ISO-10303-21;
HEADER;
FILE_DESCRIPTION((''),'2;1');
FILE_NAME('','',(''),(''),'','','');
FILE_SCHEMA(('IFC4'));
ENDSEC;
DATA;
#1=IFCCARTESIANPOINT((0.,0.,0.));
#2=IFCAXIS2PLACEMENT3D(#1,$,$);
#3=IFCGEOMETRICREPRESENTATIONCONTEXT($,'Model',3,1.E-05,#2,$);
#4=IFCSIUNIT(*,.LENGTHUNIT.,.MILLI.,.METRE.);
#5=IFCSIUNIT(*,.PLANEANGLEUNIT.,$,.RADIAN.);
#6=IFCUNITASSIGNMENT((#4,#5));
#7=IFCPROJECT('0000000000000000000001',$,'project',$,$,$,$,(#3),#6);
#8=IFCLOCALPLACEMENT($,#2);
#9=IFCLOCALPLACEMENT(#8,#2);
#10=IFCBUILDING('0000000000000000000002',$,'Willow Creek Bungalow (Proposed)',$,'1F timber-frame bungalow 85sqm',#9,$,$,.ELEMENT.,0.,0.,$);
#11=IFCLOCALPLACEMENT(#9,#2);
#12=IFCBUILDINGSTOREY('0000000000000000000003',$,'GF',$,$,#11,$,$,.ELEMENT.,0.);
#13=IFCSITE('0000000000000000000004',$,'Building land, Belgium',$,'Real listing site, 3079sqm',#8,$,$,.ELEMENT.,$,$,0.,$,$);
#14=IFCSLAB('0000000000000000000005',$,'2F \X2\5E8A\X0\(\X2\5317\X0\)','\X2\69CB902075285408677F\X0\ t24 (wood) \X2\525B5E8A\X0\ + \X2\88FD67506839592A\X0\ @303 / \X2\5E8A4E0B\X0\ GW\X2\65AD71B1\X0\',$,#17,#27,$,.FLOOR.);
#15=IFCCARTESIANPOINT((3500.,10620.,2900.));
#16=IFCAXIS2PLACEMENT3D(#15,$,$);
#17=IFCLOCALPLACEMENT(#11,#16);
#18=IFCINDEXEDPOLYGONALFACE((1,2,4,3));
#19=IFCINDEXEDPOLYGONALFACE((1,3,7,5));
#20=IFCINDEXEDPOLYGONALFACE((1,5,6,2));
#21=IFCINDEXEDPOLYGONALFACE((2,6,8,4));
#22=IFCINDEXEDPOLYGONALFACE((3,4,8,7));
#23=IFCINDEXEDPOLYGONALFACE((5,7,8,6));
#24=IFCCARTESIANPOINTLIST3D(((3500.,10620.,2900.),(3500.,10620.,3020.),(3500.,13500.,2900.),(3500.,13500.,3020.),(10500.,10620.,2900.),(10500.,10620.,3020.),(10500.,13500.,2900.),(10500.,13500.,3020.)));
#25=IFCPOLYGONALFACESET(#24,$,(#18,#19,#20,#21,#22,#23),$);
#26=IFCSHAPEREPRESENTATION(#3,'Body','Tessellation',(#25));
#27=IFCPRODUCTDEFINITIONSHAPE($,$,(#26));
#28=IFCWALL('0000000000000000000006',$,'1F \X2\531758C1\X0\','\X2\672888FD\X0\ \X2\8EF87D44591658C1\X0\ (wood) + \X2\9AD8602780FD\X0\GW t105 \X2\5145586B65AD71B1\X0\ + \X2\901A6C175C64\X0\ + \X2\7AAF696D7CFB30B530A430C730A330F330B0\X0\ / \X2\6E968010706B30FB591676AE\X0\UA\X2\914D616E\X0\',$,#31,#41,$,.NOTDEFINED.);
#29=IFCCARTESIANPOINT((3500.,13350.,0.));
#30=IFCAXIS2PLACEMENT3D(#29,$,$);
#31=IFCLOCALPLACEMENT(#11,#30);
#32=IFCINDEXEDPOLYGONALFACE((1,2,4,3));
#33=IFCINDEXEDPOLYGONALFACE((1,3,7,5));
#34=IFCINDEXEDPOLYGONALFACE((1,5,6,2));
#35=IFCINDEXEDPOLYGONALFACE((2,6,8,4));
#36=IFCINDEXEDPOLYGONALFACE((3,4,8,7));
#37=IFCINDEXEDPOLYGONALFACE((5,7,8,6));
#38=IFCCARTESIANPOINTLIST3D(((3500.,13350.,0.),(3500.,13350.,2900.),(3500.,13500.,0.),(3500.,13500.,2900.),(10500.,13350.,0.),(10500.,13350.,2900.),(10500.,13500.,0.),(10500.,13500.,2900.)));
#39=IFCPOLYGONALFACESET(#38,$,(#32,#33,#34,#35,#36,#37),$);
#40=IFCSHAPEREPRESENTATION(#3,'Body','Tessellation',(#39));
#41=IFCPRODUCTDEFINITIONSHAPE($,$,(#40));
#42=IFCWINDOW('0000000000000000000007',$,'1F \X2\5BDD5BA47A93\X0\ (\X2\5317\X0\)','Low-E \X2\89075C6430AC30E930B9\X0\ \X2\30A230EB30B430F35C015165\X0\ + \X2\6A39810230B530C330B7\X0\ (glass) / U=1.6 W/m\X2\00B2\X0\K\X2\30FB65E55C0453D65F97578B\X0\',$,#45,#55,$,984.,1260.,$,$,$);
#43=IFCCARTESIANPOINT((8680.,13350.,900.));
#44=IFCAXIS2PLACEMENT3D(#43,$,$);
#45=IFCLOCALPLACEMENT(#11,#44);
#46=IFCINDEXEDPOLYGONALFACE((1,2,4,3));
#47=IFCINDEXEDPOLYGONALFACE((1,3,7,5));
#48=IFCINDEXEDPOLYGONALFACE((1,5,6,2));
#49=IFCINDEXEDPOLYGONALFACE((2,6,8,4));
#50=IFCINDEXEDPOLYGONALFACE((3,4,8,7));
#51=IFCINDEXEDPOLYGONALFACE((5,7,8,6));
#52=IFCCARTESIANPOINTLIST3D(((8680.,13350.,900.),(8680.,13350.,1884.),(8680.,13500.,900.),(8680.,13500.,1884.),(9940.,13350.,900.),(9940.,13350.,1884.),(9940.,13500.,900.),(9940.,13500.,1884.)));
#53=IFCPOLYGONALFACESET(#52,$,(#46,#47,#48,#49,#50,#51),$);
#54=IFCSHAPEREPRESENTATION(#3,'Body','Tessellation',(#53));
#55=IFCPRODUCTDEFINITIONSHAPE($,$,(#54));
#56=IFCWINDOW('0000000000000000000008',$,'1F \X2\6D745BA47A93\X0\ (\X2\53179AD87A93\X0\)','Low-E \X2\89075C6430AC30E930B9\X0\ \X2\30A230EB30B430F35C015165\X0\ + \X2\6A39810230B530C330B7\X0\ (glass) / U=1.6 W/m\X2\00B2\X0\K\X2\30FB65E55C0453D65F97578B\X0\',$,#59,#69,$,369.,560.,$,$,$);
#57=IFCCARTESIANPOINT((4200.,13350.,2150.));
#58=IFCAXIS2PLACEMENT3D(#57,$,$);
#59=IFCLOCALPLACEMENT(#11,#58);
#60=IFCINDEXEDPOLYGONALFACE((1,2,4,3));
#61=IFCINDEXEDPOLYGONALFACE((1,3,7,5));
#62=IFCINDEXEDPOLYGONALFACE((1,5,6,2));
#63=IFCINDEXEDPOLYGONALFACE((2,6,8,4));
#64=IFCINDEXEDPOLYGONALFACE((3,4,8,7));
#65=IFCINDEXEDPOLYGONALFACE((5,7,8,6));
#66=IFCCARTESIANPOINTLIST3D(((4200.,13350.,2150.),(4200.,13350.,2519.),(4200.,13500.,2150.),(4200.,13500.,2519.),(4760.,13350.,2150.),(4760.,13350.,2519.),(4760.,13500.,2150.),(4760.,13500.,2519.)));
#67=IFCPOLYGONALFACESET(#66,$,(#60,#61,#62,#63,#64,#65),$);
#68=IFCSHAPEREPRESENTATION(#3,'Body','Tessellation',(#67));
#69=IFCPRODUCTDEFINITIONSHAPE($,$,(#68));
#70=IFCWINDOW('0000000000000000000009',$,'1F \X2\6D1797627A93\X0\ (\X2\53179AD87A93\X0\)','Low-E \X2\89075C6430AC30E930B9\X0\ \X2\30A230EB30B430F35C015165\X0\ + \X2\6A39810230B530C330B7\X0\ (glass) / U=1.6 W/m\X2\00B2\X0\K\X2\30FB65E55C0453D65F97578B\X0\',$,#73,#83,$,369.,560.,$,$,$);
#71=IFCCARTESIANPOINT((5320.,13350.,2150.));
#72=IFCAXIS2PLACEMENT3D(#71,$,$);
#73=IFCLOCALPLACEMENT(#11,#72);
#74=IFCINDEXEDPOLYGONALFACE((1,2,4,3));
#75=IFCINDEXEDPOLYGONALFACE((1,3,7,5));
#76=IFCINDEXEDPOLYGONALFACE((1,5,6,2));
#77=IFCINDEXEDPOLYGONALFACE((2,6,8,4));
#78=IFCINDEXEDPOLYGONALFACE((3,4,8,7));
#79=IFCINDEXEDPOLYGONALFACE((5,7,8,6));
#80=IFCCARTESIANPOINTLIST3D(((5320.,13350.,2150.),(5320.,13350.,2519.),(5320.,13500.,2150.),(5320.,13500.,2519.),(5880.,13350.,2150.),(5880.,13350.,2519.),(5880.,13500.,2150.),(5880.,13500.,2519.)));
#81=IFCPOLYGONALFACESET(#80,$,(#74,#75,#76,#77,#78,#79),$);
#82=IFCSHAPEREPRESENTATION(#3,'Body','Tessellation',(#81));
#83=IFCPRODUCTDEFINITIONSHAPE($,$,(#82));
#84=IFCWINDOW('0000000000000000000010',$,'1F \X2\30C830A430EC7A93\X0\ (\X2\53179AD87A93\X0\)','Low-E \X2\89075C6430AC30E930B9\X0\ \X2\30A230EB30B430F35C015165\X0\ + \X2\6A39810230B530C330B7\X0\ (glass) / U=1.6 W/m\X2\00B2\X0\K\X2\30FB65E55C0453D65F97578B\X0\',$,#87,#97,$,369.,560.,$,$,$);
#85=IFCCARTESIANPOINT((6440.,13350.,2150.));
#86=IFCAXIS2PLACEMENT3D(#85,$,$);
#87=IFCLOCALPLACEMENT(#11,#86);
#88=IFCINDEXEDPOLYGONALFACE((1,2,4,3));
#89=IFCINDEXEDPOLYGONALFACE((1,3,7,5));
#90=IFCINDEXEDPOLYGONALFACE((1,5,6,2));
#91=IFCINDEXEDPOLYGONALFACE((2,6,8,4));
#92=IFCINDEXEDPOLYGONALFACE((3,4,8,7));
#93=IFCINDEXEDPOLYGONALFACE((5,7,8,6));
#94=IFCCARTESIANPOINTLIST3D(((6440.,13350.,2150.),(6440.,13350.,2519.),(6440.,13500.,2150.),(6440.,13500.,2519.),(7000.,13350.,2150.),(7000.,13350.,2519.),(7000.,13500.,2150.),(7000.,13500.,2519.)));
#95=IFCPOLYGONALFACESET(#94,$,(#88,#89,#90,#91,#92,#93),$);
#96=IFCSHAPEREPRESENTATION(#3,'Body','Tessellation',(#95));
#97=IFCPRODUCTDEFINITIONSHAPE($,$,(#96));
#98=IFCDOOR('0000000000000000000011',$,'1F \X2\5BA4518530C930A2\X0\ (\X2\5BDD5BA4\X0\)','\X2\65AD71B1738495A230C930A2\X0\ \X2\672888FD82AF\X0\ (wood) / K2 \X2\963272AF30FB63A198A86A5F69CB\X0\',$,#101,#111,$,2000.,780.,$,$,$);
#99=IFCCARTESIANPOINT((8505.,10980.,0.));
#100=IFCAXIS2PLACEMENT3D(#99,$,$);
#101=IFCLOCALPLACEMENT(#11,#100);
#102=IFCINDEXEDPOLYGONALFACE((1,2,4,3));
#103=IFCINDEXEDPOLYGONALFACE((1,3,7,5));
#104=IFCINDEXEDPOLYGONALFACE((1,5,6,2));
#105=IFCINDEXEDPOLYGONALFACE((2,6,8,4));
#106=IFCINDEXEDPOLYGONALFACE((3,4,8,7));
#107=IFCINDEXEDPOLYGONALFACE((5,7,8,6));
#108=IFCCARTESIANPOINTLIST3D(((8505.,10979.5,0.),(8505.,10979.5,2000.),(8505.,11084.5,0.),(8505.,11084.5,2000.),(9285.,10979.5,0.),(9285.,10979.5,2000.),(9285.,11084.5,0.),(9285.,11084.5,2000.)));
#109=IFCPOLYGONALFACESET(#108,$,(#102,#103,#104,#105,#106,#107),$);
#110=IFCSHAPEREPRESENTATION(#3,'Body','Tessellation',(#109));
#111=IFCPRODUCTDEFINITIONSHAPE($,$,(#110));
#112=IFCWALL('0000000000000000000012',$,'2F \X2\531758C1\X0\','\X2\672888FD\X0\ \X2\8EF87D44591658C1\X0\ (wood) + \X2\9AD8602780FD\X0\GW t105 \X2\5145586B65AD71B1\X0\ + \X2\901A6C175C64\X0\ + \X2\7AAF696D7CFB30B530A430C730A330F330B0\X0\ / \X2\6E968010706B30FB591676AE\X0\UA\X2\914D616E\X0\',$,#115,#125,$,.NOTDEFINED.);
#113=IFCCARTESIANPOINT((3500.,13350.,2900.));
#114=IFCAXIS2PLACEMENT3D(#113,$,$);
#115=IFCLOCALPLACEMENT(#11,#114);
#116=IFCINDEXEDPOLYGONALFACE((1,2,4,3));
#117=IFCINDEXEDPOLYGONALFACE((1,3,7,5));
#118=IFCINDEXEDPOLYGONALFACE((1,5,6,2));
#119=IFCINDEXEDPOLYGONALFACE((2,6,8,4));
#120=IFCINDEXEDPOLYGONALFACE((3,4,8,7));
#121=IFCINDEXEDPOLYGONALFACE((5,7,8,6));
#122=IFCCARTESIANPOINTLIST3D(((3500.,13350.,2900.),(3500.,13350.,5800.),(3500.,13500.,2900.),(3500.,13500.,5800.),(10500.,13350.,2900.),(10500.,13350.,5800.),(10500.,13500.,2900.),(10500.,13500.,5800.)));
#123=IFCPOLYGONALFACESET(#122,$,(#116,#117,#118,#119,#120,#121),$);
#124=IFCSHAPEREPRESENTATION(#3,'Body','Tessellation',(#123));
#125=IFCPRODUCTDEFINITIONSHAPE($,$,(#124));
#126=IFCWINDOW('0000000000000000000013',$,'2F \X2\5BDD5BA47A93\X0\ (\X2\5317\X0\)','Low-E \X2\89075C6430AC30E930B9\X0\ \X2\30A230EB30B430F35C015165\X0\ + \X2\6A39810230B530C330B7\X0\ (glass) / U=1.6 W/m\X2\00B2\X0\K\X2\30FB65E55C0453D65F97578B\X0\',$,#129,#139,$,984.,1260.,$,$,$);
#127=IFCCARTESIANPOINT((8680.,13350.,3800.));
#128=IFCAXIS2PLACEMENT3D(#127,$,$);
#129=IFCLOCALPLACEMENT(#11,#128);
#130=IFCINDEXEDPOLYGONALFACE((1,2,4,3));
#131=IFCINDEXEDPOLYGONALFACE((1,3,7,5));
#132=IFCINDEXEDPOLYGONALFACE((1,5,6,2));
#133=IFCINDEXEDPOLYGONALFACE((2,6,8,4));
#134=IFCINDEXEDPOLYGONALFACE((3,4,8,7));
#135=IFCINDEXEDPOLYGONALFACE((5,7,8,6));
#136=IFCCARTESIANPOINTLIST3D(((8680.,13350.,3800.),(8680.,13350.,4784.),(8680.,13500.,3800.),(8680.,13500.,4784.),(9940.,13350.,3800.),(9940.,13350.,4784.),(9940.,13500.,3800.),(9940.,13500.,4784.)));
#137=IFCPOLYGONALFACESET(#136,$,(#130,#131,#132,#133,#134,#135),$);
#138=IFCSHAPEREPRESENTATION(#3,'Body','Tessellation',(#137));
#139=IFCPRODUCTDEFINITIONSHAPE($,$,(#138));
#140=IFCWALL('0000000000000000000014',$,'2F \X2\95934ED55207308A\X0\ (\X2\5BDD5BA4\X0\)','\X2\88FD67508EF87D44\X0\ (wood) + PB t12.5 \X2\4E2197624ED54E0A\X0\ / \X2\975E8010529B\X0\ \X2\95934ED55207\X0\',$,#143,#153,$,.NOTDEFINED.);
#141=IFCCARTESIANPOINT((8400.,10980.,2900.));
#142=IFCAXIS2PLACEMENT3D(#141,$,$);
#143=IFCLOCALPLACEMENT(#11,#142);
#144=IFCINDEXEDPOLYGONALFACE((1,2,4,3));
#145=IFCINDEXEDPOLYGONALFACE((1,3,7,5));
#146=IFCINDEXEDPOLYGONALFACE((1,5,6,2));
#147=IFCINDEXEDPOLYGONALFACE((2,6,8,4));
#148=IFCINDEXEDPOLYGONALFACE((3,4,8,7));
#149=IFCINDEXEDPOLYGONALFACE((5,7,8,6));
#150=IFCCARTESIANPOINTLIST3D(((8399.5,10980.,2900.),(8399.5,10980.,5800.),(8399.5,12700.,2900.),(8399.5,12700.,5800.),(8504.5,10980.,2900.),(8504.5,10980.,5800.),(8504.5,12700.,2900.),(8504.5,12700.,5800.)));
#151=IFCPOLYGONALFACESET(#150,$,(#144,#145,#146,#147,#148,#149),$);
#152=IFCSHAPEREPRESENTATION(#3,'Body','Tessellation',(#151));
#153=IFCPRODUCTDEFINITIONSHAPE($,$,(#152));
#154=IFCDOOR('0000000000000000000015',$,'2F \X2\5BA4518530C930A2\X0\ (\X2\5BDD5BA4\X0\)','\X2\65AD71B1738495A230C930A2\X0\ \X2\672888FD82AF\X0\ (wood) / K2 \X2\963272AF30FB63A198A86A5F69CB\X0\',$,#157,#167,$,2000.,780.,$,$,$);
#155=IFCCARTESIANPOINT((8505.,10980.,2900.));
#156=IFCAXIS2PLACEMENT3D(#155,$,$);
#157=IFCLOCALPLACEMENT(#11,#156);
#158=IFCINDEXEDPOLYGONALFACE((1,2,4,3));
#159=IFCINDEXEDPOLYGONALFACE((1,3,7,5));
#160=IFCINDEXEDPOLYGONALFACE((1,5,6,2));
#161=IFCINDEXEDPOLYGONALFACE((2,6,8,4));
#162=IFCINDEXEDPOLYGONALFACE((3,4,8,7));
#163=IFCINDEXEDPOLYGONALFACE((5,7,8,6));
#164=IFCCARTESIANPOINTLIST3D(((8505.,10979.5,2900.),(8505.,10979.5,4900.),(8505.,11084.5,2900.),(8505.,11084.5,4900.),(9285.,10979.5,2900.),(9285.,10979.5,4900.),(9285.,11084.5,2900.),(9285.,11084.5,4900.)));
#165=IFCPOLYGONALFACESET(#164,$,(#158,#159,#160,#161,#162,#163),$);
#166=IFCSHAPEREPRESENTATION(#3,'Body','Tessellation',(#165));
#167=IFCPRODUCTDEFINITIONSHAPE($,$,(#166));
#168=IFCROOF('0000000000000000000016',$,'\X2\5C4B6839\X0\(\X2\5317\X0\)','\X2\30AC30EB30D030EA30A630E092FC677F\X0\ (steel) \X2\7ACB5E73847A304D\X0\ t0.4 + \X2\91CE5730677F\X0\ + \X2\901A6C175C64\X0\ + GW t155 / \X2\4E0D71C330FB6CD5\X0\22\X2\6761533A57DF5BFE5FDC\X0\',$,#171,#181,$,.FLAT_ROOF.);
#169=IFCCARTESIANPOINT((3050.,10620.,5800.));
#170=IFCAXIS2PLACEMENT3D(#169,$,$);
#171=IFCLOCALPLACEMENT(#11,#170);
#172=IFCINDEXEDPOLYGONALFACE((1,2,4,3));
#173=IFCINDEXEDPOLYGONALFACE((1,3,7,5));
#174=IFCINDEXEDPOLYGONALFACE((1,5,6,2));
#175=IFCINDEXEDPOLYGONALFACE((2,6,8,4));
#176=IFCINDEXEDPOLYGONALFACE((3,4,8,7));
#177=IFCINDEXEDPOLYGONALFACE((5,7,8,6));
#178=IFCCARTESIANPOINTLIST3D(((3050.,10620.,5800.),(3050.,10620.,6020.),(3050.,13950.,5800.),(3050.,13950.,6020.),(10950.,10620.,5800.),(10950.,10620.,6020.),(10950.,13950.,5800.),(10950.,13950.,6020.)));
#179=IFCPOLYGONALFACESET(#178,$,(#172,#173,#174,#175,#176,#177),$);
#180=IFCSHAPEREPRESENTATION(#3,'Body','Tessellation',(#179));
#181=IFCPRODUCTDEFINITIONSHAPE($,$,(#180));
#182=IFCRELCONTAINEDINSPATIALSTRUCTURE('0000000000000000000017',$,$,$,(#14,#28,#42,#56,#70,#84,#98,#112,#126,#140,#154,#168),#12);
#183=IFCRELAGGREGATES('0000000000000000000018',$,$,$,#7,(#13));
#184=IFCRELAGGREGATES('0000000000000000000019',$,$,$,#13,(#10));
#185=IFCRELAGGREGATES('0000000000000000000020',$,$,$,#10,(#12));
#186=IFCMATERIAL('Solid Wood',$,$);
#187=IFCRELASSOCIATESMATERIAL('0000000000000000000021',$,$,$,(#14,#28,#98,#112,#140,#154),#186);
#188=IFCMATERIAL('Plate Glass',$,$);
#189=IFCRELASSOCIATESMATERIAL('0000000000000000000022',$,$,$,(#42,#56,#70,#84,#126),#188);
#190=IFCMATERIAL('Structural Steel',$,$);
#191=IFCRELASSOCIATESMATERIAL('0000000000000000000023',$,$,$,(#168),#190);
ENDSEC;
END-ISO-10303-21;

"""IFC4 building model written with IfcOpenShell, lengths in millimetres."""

from ifc_helpers import new_model, si_unit, frame, frame_2d, origin, place, context, project, spatial, rectangle, extrude, material, element, fill, save


model = new_model("IFC4")

# Units and contexts
model_context = context("Model", 3, precision=1e-05, world=origin())
ifc_project = project(units=[si_unit("LENGTHUNIT", "METRE", prefix="MILLI"), si_unit("PLANEANGLEUNIT", "RADIAN")], contexts=[model_context])

# Site, building, storey
site_placement = place(None, origin())
site = spatial("IfcSite", under=ifc_project, at=site_placement, Name="Building land, Belgium", ObjectType="Real listing site, 3079sqm", CompositionType="ELEMENT", RefElevation=0.0)
building_placement = place(site_placement, origin())
building = spatial("IfcBuilding", under=site, at=building_placement, Name="Willow Creek Bungalow (Proposed)", ObjectType="1F timber-frame bungalow 85sqm", CompositionType="ELEMENT", ElevationOfRefHeight=0.0, ElevationOfTerrain=0.0)
storey_placement = place(building_placement, origin())
storey = spatial("IfcBuildingStorey", under=building, at=storey_placement, Name="GF", CompositionType="ELEMENT", Elevation=0.0)

# Slab
ifc_material_1 = material(Name="Solid Wood")
slab_placement = place(storey_placement, frame((3500.0, 10620.0, 2900.0)))
element("IfcSlab", 1, at=slab_placement, inside=storey, material=ifc_material_1, Name="2F 床(北)", Description="構造用合板 t24 (wood) 剛床 + 製材根太 @303 / 床下 GW断熱", PredefinedType="FLOOR", context=model_context, shape_type="SweptSolid", body=[
    extrude(rectangle(XDim=7000.0, YDim=2880.0, at=frame_2d((3500.0, 1440.0))), frame((3500.0, 10620.0, 2900.0)), (0.0, 0.0, 1.0), 120.0),
])

# Wall, openings, windows
wall_1_placement = place(storey_placement, frame((3500.0, 13350.0, 0.0)))
wall_1 = element("IfcWall", 2, at=wall_1_placement, inside=storey, material=ifc_material_1, Name="1F 北壁", Description="木製 軸組外壁 (wood) + 高性能GW t105 充填断熱 + 通気層 + 窯業系サイディング / 準耐火・外皮UA配慮", PredefinedType="NOTDEFINED", context=model_context, shape_type="SweptSolid", body=[
    extrude(rectangle(XDim=7000.0, YDim=150.0, at=frame_2d((3500.0, 75.0))), frame((3500.0, 13350.0, 0.0)), (0.0, 0.0, 1.0), 2900.0),
])
opening_1_placement = place(storey_placement, frame((8680.0, 13350.0, 900.0)))
opening_1 = element("IfcOpeningElement", 3, at=opening_1_placement, cuts=wall_1, PredefinedType="NOTDEFINED", context=model_context, shape_type="SweptSolid", body=[
    extrude(rectangle(XDim=1260.0, YDim=150.0, at=frame_2d((630.0, 75.0))), frame((8680.0, 13350.0, 900.0)), (0.0, 0.0, 1.0), 984.0),
])
opening_2_placement = place(storey_placement, frame((4200.0, 13350.0, 2150.0)))
opening_2 = element("IfcOpeningElement", 4, at=opening_2_placement, cuts=wall_1, PredefinedType="NOTDEFINED", context=model_context, shape_type="SweptSolid", body=[
    extrude(rectangle(XDim=560.0, YDim=150.0, at=frame_2d((280.0, 75.0))), frame((4200.0, 13350.0, 2150.0)), (0.0, 0.0, 1.0), 369.0),
])
opening_3_placement = place(storey_placement, frame((5320.0, 13350.0, 2150.0)))
opening_3 = element("IfcOpeningElement", 5, at=opening_3_placement, cuts=wall_1, PredefinedType="NOTDEFINED", context=model_context, shape_type="SweptSolid", body=[
    extrude(rectangle(XDim=560.0, YDim=150.0, at=frame_2d((280.0, 75.0))), frame((5320.0, 13350.0, 2150.0)), (0.0, 0.0, 1.0), 369.0),
])
opening_4_placement = place(storey_placement, frame((6440.0, 13350.0, 2150.0)))
opening_4 = element("IfcOpeningElement", 6, at=opening_4_placement, cuts=wall_1, PredefinedType="NOTDEFINED", context=model_context, shape_type="SweptSolid", body=[
    extrude(rectangle(XDim=560.0, YDim=150.0, at=frame_2d((280.0, 75.0))), frame((6440.0, 13350.0, 2150.0)), (0.0, 0.0, 1.0), 369.0),
])
ifc_material_2 = material(Name="Plate Glass")
window_1_placement = place(storey_placement, frame((8680.0, 13350.0, 900.0)))
window_1 = element("IfcWindow", 7, at=window_1_placement, inside=storey, material=ifc_material_2, Name="1F 寝室窓 (北)", Description="Low-E 複層ガラス アルゴン封入 + 樹脂サッシ (glass) / U=1.6 W/m²K・日射取得型", OverallHeight=984.0, OverallWidth=1260.0, context=model_context, shape_type="SweptSolid", body=[
    extrude(rectangle(XDim=1260.0, YDim=150.0, at=frame_2d((630.0, 75.0))), frame((8680.0, 13350.0, 900.0)), (0.0, 0.0, 1.0), 984.0),
])
fill(opening_1, window_1)
window_2_placement = place(storey_placement, frame((4200.0, 13350.0, 2150.0)))
window_2 = element("IfcWindow", 8, at=window_2_placement, inside=storey, material=ifc_material_2, Name="1F 浴室窓 (北高窓)", Description="Low-E 複層ガラス アルゴン封入 + 樹脂サッシ (glass) / U=1.6 W/m²K・日射取得型", OverallHeight=369.0, OverallWidth=560.0, context=model_context, shape_type="SweptSolid", body=[
    extrude(rectangle(XDim=560.0, YDim=150.0, at=frame_2d((280.0, 75.0))), frame((4200.0, 13350.0, 2150.0)), (0.0, 0.0, 1.0), 369.0),
])
fill(opening_2, window_2)
window_3_placement = place(storey_placement, frame((5320.0, 13350.0, 2150.0)))
window_3 = element("IfcWindow", 9, at=window_3_placement, inside=storey, material=ifc_material_2, Name="1F 洗面窓 (北高窓)", Description="Low-E 複層ガラス アルゴン封入 + 樹脂サッシ (glass) / U=1.6 W/m²K・日射取得型", OverallHeight=369.0, OverallWidth=560.0, context=model_context, shape_type="SweptSolid", body=[
    extrude(rectangle(XDim=560.0, YDim=150.0, at=frame_2d((280.0, 75.0))), frame((5320.0, 13350.0, 2150.0)), (0.0, 0.0, 1.0), 369.0),
])
fill(opening_3, window_3)
window_4_placement = place(storey_placement, frame((6440.0, 13350.0, 2150.0)))
window_4 = element("IfcWindow", 10, at=window_4_placement, inside=storey, material=ifc_material_2, Name="1F トイレ窓 (北高窓)", Description="Low-E 複層ガラス アルゴン封入 + 樹脂サッシ (glass) / U=1.6 W/m²K・日射取得型", OverallHeight=369.0, OverallWidth=560.0, context=model_context, shape_type="SweptSolid", body=[
    extrude(rectangle(XDim=560.0, YDim=150.0, at=frame_2d((280.0, 75.0))), frame((6440.0, 13350.0, 2150.0)), (0.0, 0.0, 1.0), 369.0),
])
fill(opening_4, window_4)

# Door
door_1_placement = place(storey_placement, frame((8505.0, 10980.0, 0.0)))
element("IfcDoor", 11, at=door_1_placement, inside=storey, material=ifc_material_1, Name="1F 室内ドア (寝室)", Description="断熱玄関ドア 木製芯 (wood) / K2 防犯・採風機構", OverallHeight=2000.0, OverallWidth=780.0, context=model_context, shape_type="SweptSolid", body=[
    extrude(rectangle(XDim=780.0, YDim=105.0, at=frame_2d((390.0, 52.0))), frame((8505.0, 10980.0, 0.0)), (0.0, 0.0, 1.0), 2000.0),
])

# Wall, opening, window
wall_2_placement = place(storey_placement, frame((3500.0, 13350.0, 2900.0)))
wall_2 = element("IfcWall", 12, at=wall_2_placement, inside=storey, material=ifc_material_1, Name="2F 北壁", Description="木製 軸組外壁 (wood) + 高性能GW t105 充填断熱 + 通気層 + 窯業系サイディング / 準耐火・外皮UA配慮", PredefinedType="NOTDEFINED", context=model_context, shape_type="SweptSolid", body=[
    extrude(rectangle(XDim=7000.0, YDim=150.0, at=frame_2d((3500.0, 75.0))), frame((3500.0, 13350.0, 2900.0)), (0.0, 0.0, 1.0), 2900.0),
])
opening_5_placement = place(storey_placement, frame((8680.0, 13350.0, 3800.0)))
opening_5 = element("IfcOpeningElement", 13, at=opening_5_placement, cuts=wall_2, PredefinedType="NOTDEFINED", context=model_context, shape_type="SweptSolid", body=[
    extrude(rectangle(XDim=1260.0, YDim=150.0, at=frame_2d((630.0, 75.0))), frame((8680.0, 13350.0, 3800.0)), (0.0, 0.0, 1.0), 984.0),
])
window_5_placement = place(storey_placement, frame((8680.0, 13350.0, 3800.0)))
window_5 = element("IfcWindow", 14, at=window_5_placement, inside=storey, material=ifc_material_2, Name="2F 寝室窓 (北)", Description="Low-E 複層ガラス アルゴン封入 + 樹脂サッシ (glass) / U=1.6 W/m²K・日射取得型", OverallHeight=984.0, OverallWidth=1260.0, context=model_context, shape_type="SweptSolid", body=[
    extrude(rectangle(XDim=1260.0, YDim=150.0, at=frame_2d((630.0, 75.0))), frame((8680.0, 13350.0, 3800.0)), (0.0, 0.0, 1.0), 984.0),
])
fill(opening_5, window_5)

# Wall
wall_3_placement = place(storey_placement, frame((8400.0, 10980.0, 2900.0)))
element("IfcWall", 15, at=wall_3_placement, inside=storey, material=ifc_material_1, Name="2F 間仕切り (寝室)", Description="製材軸組 (wood) + PB t12.5 両面仕上 / 非耐力 間仕切", PredefinedType="NOTDEFINED", context=model_context, shape_type="SweptSolid", body=[
    extrude(rectangle(XDim=105.0, YDim=1720.0, at=frame_2d((52.0, 860.0))), frame((8400.0, 10980.0, 2900.0)), (0.0, 0.0, 1.0), 2900.0),
])

# Door
door_2_placement = place(storey_placement, frame((8505.0, 10980.0, 2900.0)))
element("IfcDoor", 16, at=door_2_placement, inside=storey, material=ifc_material_1, Name="2F 室内ドア (寝室)", Description="断熱玄関ドア 木製芯 (wood) / K2 防犯・採風機構", OverallHeight=2000.0, OverallWidth=780.0, context=model_context, shape_type="SweptSolid", body=[
    extrude(rectangle(XDim=780.0, YDim=105.0, at=frame_2d((390.0, 52.0))), frame((8505.0, 10980.0, 2900.0)), (0.0, 0.0, 1.0), 2000.0),
])

# Roof
ifc_material_3 = material(Name="Structural Steel")
roof_placement = place(storey_placement, frame((3050.0, 10620.0, 5800.0)))
element("IfcRoof", 17, at=roof_placement, inside=storey, material=ifc_material_3, Name="屋根(北)", Description="ガルバリウム鋼板 (steel) 立平葺き t0.4 + 野地板 + 通気層 + GW t155 / 不燃・法22条区域対応", PredefinedType="FLAT_ROOF", context=model_context, shape_type="SweptSolid", body=[
    extrude(rectangle(XDim=7900.0, YDim=3330.0, at=frame_2d((3950.0, 1665.0))), frame((3050.0, 10620.0, 5800.0)), (0.0, 0.0, 1.0), 220.0),
])

save(model, "model.ifc")
